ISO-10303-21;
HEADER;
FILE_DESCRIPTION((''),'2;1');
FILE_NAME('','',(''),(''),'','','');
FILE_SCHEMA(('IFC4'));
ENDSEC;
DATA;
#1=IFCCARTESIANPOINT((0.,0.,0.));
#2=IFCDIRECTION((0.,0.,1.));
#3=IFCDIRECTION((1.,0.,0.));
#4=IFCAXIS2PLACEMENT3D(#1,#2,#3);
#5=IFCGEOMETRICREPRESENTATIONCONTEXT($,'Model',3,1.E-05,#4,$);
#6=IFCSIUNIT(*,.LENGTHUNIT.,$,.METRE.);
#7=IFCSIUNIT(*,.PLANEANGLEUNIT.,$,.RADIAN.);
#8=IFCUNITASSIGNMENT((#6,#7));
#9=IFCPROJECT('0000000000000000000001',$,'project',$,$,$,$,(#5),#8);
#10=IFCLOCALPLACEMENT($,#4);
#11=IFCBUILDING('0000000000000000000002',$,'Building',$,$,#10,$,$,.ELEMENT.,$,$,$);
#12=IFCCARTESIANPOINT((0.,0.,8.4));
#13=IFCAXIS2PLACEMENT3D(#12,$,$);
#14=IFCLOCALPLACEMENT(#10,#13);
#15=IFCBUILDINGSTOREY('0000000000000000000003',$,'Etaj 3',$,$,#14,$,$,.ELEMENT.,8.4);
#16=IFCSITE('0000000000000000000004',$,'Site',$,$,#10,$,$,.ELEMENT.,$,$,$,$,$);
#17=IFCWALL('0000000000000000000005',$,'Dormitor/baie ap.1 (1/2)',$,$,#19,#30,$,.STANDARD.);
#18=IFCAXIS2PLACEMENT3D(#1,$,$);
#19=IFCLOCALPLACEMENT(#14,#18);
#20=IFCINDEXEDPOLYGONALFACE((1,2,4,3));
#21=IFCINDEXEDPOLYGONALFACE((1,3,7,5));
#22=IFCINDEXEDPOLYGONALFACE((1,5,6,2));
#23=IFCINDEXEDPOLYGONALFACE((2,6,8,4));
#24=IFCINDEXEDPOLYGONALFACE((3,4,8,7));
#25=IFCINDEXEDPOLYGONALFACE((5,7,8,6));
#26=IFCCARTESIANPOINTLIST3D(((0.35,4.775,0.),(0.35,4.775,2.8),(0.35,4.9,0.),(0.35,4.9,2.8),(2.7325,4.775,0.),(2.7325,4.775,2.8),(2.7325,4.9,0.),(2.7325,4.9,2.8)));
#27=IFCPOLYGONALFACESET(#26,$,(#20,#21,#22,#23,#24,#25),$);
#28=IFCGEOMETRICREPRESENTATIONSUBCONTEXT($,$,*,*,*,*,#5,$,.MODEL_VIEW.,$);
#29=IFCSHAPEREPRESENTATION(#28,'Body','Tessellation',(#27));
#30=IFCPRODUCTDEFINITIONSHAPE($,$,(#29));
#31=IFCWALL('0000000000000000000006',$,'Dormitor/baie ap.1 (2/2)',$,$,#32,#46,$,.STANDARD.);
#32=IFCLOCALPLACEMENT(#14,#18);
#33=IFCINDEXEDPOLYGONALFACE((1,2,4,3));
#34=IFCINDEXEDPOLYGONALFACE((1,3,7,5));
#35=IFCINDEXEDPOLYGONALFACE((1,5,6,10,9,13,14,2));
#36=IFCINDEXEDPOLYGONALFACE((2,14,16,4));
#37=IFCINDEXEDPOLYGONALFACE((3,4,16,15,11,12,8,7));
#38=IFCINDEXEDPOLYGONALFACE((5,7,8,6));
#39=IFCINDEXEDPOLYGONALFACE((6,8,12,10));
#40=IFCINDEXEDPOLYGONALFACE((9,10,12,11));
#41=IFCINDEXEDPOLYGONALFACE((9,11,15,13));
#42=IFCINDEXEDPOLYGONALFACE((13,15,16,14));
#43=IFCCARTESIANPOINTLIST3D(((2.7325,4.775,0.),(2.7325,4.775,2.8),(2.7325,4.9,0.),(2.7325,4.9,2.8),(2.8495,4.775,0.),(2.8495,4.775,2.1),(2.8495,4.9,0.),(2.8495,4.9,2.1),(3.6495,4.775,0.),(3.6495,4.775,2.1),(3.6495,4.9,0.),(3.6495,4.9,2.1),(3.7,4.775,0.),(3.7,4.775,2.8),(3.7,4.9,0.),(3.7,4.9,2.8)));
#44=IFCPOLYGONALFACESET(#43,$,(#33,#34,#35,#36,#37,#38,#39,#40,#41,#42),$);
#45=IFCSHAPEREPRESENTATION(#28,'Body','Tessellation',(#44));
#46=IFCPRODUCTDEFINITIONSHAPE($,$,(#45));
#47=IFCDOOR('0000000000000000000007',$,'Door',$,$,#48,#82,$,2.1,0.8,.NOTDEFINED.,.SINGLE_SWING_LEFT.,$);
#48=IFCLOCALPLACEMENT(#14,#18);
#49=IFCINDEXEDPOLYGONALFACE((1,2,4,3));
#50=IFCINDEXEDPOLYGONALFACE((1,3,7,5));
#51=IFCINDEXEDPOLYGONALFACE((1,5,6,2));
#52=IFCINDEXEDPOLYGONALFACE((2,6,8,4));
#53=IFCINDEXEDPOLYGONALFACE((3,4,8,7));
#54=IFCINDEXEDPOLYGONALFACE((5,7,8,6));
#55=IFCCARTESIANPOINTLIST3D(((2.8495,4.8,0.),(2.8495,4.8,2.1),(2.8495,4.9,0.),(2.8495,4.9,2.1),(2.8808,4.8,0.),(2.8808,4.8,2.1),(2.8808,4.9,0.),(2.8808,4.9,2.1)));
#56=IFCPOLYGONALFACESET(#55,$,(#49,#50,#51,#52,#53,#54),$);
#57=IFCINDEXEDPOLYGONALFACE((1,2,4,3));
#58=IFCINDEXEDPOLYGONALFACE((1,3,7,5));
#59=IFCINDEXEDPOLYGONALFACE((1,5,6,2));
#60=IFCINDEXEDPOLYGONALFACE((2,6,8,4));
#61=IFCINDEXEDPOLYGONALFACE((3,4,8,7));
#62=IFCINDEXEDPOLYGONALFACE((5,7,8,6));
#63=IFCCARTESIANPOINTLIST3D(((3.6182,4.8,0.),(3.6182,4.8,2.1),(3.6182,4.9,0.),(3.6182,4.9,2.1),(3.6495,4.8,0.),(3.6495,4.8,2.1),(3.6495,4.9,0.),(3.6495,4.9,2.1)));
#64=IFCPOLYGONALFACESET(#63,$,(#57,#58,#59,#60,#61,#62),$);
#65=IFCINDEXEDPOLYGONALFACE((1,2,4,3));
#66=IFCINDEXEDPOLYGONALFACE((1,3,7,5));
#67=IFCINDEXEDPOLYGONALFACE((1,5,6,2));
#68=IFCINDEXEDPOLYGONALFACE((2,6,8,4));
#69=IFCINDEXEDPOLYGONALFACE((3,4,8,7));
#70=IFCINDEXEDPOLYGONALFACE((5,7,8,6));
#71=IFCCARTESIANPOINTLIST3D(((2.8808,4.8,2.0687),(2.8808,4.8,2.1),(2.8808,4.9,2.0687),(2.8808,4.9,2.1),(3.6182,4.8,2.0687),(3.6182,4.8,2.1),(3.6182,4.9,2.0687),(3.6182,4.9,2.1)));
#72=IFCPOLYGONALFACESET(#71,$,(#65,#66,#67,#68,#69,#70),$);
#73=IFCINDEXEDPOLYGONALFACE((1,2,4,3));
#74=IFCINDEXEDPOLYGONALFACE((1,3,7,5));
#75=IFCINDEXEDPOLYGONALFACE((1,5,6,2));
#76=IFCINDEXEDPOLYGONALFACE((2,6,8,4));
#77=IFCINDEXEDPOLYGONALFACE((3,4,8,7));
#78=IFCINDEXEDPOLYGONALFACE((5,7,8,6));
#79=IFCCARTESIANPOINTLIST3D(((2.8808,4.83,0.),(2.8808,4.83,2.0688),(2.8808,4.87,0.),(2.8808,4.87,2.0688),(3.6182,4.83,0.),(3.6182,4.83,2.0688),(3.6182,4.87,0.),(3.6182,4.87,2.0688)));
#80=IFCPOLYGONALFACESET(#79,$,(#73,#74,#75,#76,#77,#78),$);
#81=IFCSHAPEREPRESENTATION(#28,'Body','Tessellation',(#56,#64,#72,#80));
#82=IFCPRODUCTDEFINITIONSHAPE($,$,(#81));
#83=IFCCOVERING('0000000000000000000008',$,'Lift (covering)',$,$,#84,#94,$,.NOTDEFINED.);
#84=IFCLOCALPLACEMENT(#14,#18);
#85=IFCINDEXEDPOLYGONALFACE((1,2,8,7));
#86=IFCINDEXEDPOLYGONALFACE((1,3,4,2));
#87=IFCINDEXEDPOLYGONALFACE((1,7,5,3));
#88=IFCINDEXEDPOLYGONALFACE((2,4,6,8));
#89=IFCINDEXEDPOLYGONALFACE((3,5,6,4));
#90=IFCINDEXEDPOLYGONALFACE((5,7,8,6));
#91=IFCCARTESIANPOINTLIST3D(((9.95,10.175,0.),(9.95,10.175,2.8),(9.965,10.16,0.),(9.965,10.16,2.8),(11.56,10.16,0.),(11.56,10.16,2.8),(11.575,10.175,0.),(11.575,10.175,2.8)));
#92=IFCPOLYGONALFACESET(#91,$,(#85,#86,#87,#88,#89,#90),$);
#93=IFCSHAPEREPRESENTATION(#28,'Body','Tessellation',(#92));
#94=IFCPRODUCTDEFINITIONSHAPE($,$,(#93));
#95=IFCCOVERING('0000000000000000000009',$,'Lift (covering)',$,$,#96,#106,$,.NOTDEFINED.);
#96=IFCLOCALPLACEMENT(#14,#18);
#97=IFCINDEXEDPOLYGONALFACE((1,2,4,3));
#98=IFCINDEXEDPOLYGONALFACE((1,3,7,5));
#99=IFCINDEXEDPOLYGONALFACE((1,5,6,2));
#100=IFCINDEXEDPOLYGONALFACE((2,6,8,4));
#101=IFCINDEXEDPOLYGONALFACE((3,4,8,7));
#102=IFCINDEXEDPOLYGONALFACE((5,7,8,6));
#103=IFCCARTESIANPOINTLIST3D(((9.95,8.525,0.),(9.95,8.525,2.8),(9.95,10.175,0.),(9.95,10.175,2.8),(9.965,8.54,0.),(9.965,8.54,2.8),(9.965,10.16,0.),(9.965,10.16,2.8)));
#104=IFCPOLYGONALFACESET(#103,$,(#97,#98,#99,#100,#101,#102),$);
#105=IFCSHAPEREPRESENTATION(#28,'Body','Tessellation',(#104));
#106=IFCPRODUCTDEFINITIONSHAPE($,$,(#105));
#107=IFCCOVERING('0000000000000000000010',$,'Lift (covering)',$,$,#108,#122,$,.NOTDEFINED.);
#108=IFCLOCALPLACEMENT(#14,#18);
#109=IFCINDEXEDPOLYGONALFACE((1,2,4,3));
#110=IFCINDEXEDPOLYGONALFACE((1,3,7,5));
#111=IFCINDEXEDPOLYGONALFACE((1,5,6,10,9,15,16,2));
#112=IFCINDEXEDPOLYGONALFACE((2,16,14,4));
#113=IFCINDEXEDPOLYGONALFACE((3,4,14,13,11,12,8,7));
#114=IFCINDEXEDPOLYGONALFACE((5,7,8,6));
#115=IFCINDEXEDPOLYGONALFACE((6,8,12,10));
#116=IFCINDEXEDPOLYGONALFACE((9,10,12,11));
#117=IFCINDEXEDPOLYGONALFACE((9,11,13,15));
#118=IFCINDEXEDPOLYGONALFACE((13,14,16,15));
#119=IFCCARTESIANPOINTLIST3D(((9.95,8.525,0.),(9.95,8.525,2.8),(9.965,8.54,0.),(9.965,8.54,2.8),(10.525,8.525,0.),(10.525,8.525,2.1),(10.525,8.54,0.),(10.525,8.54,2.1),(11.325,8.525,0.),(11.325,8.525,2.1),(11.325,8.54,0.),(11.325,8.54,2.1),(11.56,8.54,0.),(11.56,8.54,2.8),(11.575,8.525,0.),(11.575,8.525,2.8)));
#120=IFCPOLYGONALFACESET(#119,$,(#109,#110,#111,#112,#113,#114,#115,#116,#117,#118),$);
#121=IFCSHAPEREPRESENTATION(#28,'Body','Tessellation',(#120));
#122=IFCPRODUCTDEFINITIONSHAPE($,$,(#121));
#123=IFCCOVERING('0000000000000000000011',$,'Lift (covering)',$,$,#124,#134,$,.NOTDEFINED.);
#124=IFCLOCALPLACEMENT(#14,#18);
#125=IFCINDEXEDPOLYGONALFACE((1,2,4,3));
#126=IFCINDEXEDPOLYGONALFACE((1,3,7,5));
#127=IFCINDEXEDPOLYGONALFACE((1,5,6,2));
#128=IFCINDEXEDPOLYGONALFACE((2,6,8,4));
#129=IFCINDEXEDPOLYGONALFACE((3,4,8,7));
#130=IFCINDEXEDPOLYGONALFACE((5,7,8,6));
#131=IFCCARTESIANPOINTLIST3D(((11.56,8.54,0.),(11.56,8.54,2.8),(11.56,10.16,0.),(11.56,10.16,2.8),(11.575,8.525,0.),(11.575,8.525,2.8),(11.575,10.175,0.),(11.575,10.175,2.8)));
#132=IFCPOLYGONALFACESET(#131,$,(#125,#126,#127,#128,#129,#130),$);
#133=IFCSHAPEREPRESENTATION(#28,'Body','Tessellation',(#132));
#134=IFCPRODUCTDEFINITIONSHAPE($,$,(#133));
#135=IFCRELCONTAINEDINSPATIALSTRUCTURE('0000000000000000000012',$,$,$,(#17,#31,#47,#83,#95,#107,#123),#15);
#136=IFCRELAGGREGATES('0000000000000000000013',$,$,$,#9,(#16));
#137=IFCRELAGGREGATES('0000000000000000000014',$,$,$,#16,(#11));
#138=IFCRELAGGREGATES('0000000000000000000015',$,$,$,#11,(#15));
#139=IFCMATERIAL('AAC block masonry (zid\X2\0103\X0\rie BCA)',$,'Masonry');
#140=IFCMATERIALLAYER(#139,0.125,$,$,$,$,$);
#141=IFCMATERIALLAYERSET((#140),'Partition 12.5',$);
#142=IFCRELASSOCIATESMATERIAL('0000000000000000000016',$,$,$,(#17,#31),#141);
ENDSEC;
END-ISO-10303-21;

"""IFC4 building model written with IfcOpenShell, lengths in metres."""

from ifc_helpers import new_model, si_unit, frame, frame_2d, origin, origin_with_axes, origin_2d, place, context, subcontext, project, spatial, polyline, rectangle, outline, extrude, material, layer, layer_set, layer_usage, element, fill, save


model = new_model("IFC4")

# Units and contexts
model_context = context("Model", 3, precision=1e-05, world=origin_with_axes())
sub_context = subcontext(model_context, None, None, "MODEL_VIEW")
ifc_project = project(units=[si_unit("LENGTHUNIT", "METRE"), si_unit("PLANEANGLEUNIT", "RADIAN")], contexts=[model_context])

# Site, building, storey
placement = place(None, origin_with_axes())
site = spatial("IfcSite", under=ifc_project, at=placement, Name="Site", CompositionType="ELEMENT")
building = spatial("IfcBuilding", under=site, at=placement, Name="Building", CompositionType="ELEMENT")
storey_placement = place(placement, frame((0.0, 0.0, 8.4)))
storey = spatial("IfcBuildingStorey", under=building, at=storey_placement, Name="Etaj 3", CompositionType="ELEMENT", Elevation=8.4)

# Wall
ifc_material_1 = material(Name="AAC block masonry (zidărie BCA)", Category="Masonry")
ifc_layer_1 = layer(ifc_material_1, 0.125)
ifc_layer_set_1 = layer_set([ifc_layer_1], Name="Partition 12.5")
ifc_layer_usage_1 = layer_usage(ifc_layer_set_1, "AXIS2", "POSITIVE", -0.0625)
wall_1_placement = place(storey_placement, frame((0.35, 4.8375, 0.0), x_axis=(1.0, 0.0, 0.0)))
element("IfcWall", 1, at=wall_1_placement, inside=storey, material=ifc_layer_usage_1, Name="Dormitor/baie ap.1 (1/2)", PredefinedType="STANDARD", context=sub_context, shape_type="SweptSolid", body=[
    extrude(rectangle(XDim=2.3825, YDim=0.125, at=frame_2d((1.1912, 0.0))), origin(), (0.0, 0.0, 1.0), 2.8),
])

# Wall, opening, door
wall_2_placement = place(storey_placement, frame((2.7325, 4.8375, 0.0), x_axis=(1.0, 0.0, 0.0)))
wall_2 = element("IfcWall", 2, at=wall_2_placement, inside=storey, material=ifc_layer_usage_1, Name="Dormitor/baie ap.1 (2/2)", PredefinedType="STANDARD", context=sub_context, shape_type="SweptSolid", body=[
    extrude(rectangle(XDim=0.9675, YDim=0.125, at=frame_2d((0.4838, 0.0))), origin(), (0.0, 0.0, 1.0), 2.8),
])
opening_1_placement = place(wall_2_placement, frame((0.517, 0.1125, 0.0), z_axis=(0.0, -1.0, 0.0), x_axis=(1.0, 0.0, 0.0)))
opening_1 = element("IfcOpeningElement", 3, at=opening_1_placement, cuts=wall_2, PredefinedType="OPENING", context=sub_context, shape_type="SweptSolid", body=[
    extrude(rectangle(XDim=0.8, YDim=2.1, at=frame_2d((0.0, 1.05))), origin(), (0.0, 0.0, 1.0), 0.225),
])
door_placement = place(wall_2_placement, frame((0.517, 0.0625, 0.0), z_axis=(0.0, -1.0, 0.0), x_axis=(1.0, 0.0, 0.0)))
door = element("IfcDoor", 4, at=door_placement, inside=storey, Name="Door", OperationType="SINGLE_SWING_LEFT", OverallHeight=2.1, OverallWidth=0.8, PredefinedType="NOTDEFINED", context=sub_context, shape_type="SweptSolid", body=[
    extrude(rectangle(XDim=0.0312, YDim=2.1, at=origin_2d()), frame((-0.3844, 1.05, 0.0)), (0.0, 0.0, 1.0), 0.1),
    extrude(rectangle(XDim=0.0312, YDim=2.1, at=origin_2d()), frame((0.3844, 1.05, 0.0)), (0.0, 0.0, 1.0), 0.1),
    extrude(rectangle(XDim=0.7375, YDim=0.0312, at=origin_2d()), frame((0.0, 2.0844, 0.0)), (0.0, 0.0, 1.0), 0.1),
    extrude(rectangle(XDim=0.7375, YDim=2.0688, at=origin_2d()), frame((0.0, 1.0344, 0.03)), (0.0, 0.0, 1.0), 0.04),
])
fill(opening_1, door)

# Coverings
covering_1_placement = place(storey_placement, origin_with_axes())
element("IfcCovering", 5, at=covering_1_placement, inside=storey, Name="Lift (covering)", PredefinedType="NOTDEFINED", context=sub_context, shape_type="SweptSolid", body=[
    extrude(outline(polyline([(11.575, 10.175), (9.95, 10.175), (9.965, 10.16), (11.56, 10.16), (11.575, 10.175)])), origin(), (0.0, 0.0, 1.0), 2.8),
])
covering_2_placement = place(storey_placement, origin_with_axes())
element("IfcCovering", 6, at=covering_2_placement, inside=storey, Name="Lift (covering)", PredefinedType="NOTDEFINED", context=sub_context, shape_type="SweptSolid", body=[
    extrude(outline(polyline([(9.95, 10.175), (9.95, 8.525), (9.965, 8.54), (9.965, 10.16), (9.95, 10.175)])), origin(), (0.0, 0.0, 1.0), 2.8),
])

# Covering, opening
covering_3_placement = place(storey_placement, origin_with_axes())
covering_3 = element("IfcCovering", 7, at=covering_3_placement, inside=storey, Name="Lift (covering)", PredefinedType="NOTDEFINED", context=sub_context, shape_type="SweptSolid", body=[
    extrude(outline(polyline([(9.95, 8.525), (11.575, 8.525), (11.56, 8.54), (9.965, 8.54), (9.95, 8.525)])), origin(), (0.0, 0.0, 1.0), 2.8),
])
opening_2_placement = place(covering_3_placement, frame((10.925, 8.59, 0.0), z_axis=(0.0, -1.0, 0.0), x_axis=(1.0, 0.0, 0.0)))
element("IfcOpeningElement", 8, at=opening_2_placement, cuts=covering_3, PredefinedType="OPENING", context=sub_context, shape_type="SweptSolid", body=[
    extrude(rectangle(XDim=0.8, YDim=2.1, at=origin_2d()), frame((0.0, 1.05, 0.0)), (0.0, 0.0, 1.0), 0.38),
])

# Covering
covering_4_placement = place(storey_placement, origin_with_axes())
element("IfcCovering", 9, at=covering_4_placement, inside=storey, Name="Lift (covering)", PredefinedType="NOTDEFINED", context=sub_context, shape_type="SweptSolid", body=[
    extrude(outline(polyline([(11.575, 8.525), (11.575, 10.175), (11.56, 10.16), (11.56, 8.54), (11.575, 8.525)])), origin(), (0.0, 0.0, 1.0), 2.8),
])

save(model, "model.ifc")
